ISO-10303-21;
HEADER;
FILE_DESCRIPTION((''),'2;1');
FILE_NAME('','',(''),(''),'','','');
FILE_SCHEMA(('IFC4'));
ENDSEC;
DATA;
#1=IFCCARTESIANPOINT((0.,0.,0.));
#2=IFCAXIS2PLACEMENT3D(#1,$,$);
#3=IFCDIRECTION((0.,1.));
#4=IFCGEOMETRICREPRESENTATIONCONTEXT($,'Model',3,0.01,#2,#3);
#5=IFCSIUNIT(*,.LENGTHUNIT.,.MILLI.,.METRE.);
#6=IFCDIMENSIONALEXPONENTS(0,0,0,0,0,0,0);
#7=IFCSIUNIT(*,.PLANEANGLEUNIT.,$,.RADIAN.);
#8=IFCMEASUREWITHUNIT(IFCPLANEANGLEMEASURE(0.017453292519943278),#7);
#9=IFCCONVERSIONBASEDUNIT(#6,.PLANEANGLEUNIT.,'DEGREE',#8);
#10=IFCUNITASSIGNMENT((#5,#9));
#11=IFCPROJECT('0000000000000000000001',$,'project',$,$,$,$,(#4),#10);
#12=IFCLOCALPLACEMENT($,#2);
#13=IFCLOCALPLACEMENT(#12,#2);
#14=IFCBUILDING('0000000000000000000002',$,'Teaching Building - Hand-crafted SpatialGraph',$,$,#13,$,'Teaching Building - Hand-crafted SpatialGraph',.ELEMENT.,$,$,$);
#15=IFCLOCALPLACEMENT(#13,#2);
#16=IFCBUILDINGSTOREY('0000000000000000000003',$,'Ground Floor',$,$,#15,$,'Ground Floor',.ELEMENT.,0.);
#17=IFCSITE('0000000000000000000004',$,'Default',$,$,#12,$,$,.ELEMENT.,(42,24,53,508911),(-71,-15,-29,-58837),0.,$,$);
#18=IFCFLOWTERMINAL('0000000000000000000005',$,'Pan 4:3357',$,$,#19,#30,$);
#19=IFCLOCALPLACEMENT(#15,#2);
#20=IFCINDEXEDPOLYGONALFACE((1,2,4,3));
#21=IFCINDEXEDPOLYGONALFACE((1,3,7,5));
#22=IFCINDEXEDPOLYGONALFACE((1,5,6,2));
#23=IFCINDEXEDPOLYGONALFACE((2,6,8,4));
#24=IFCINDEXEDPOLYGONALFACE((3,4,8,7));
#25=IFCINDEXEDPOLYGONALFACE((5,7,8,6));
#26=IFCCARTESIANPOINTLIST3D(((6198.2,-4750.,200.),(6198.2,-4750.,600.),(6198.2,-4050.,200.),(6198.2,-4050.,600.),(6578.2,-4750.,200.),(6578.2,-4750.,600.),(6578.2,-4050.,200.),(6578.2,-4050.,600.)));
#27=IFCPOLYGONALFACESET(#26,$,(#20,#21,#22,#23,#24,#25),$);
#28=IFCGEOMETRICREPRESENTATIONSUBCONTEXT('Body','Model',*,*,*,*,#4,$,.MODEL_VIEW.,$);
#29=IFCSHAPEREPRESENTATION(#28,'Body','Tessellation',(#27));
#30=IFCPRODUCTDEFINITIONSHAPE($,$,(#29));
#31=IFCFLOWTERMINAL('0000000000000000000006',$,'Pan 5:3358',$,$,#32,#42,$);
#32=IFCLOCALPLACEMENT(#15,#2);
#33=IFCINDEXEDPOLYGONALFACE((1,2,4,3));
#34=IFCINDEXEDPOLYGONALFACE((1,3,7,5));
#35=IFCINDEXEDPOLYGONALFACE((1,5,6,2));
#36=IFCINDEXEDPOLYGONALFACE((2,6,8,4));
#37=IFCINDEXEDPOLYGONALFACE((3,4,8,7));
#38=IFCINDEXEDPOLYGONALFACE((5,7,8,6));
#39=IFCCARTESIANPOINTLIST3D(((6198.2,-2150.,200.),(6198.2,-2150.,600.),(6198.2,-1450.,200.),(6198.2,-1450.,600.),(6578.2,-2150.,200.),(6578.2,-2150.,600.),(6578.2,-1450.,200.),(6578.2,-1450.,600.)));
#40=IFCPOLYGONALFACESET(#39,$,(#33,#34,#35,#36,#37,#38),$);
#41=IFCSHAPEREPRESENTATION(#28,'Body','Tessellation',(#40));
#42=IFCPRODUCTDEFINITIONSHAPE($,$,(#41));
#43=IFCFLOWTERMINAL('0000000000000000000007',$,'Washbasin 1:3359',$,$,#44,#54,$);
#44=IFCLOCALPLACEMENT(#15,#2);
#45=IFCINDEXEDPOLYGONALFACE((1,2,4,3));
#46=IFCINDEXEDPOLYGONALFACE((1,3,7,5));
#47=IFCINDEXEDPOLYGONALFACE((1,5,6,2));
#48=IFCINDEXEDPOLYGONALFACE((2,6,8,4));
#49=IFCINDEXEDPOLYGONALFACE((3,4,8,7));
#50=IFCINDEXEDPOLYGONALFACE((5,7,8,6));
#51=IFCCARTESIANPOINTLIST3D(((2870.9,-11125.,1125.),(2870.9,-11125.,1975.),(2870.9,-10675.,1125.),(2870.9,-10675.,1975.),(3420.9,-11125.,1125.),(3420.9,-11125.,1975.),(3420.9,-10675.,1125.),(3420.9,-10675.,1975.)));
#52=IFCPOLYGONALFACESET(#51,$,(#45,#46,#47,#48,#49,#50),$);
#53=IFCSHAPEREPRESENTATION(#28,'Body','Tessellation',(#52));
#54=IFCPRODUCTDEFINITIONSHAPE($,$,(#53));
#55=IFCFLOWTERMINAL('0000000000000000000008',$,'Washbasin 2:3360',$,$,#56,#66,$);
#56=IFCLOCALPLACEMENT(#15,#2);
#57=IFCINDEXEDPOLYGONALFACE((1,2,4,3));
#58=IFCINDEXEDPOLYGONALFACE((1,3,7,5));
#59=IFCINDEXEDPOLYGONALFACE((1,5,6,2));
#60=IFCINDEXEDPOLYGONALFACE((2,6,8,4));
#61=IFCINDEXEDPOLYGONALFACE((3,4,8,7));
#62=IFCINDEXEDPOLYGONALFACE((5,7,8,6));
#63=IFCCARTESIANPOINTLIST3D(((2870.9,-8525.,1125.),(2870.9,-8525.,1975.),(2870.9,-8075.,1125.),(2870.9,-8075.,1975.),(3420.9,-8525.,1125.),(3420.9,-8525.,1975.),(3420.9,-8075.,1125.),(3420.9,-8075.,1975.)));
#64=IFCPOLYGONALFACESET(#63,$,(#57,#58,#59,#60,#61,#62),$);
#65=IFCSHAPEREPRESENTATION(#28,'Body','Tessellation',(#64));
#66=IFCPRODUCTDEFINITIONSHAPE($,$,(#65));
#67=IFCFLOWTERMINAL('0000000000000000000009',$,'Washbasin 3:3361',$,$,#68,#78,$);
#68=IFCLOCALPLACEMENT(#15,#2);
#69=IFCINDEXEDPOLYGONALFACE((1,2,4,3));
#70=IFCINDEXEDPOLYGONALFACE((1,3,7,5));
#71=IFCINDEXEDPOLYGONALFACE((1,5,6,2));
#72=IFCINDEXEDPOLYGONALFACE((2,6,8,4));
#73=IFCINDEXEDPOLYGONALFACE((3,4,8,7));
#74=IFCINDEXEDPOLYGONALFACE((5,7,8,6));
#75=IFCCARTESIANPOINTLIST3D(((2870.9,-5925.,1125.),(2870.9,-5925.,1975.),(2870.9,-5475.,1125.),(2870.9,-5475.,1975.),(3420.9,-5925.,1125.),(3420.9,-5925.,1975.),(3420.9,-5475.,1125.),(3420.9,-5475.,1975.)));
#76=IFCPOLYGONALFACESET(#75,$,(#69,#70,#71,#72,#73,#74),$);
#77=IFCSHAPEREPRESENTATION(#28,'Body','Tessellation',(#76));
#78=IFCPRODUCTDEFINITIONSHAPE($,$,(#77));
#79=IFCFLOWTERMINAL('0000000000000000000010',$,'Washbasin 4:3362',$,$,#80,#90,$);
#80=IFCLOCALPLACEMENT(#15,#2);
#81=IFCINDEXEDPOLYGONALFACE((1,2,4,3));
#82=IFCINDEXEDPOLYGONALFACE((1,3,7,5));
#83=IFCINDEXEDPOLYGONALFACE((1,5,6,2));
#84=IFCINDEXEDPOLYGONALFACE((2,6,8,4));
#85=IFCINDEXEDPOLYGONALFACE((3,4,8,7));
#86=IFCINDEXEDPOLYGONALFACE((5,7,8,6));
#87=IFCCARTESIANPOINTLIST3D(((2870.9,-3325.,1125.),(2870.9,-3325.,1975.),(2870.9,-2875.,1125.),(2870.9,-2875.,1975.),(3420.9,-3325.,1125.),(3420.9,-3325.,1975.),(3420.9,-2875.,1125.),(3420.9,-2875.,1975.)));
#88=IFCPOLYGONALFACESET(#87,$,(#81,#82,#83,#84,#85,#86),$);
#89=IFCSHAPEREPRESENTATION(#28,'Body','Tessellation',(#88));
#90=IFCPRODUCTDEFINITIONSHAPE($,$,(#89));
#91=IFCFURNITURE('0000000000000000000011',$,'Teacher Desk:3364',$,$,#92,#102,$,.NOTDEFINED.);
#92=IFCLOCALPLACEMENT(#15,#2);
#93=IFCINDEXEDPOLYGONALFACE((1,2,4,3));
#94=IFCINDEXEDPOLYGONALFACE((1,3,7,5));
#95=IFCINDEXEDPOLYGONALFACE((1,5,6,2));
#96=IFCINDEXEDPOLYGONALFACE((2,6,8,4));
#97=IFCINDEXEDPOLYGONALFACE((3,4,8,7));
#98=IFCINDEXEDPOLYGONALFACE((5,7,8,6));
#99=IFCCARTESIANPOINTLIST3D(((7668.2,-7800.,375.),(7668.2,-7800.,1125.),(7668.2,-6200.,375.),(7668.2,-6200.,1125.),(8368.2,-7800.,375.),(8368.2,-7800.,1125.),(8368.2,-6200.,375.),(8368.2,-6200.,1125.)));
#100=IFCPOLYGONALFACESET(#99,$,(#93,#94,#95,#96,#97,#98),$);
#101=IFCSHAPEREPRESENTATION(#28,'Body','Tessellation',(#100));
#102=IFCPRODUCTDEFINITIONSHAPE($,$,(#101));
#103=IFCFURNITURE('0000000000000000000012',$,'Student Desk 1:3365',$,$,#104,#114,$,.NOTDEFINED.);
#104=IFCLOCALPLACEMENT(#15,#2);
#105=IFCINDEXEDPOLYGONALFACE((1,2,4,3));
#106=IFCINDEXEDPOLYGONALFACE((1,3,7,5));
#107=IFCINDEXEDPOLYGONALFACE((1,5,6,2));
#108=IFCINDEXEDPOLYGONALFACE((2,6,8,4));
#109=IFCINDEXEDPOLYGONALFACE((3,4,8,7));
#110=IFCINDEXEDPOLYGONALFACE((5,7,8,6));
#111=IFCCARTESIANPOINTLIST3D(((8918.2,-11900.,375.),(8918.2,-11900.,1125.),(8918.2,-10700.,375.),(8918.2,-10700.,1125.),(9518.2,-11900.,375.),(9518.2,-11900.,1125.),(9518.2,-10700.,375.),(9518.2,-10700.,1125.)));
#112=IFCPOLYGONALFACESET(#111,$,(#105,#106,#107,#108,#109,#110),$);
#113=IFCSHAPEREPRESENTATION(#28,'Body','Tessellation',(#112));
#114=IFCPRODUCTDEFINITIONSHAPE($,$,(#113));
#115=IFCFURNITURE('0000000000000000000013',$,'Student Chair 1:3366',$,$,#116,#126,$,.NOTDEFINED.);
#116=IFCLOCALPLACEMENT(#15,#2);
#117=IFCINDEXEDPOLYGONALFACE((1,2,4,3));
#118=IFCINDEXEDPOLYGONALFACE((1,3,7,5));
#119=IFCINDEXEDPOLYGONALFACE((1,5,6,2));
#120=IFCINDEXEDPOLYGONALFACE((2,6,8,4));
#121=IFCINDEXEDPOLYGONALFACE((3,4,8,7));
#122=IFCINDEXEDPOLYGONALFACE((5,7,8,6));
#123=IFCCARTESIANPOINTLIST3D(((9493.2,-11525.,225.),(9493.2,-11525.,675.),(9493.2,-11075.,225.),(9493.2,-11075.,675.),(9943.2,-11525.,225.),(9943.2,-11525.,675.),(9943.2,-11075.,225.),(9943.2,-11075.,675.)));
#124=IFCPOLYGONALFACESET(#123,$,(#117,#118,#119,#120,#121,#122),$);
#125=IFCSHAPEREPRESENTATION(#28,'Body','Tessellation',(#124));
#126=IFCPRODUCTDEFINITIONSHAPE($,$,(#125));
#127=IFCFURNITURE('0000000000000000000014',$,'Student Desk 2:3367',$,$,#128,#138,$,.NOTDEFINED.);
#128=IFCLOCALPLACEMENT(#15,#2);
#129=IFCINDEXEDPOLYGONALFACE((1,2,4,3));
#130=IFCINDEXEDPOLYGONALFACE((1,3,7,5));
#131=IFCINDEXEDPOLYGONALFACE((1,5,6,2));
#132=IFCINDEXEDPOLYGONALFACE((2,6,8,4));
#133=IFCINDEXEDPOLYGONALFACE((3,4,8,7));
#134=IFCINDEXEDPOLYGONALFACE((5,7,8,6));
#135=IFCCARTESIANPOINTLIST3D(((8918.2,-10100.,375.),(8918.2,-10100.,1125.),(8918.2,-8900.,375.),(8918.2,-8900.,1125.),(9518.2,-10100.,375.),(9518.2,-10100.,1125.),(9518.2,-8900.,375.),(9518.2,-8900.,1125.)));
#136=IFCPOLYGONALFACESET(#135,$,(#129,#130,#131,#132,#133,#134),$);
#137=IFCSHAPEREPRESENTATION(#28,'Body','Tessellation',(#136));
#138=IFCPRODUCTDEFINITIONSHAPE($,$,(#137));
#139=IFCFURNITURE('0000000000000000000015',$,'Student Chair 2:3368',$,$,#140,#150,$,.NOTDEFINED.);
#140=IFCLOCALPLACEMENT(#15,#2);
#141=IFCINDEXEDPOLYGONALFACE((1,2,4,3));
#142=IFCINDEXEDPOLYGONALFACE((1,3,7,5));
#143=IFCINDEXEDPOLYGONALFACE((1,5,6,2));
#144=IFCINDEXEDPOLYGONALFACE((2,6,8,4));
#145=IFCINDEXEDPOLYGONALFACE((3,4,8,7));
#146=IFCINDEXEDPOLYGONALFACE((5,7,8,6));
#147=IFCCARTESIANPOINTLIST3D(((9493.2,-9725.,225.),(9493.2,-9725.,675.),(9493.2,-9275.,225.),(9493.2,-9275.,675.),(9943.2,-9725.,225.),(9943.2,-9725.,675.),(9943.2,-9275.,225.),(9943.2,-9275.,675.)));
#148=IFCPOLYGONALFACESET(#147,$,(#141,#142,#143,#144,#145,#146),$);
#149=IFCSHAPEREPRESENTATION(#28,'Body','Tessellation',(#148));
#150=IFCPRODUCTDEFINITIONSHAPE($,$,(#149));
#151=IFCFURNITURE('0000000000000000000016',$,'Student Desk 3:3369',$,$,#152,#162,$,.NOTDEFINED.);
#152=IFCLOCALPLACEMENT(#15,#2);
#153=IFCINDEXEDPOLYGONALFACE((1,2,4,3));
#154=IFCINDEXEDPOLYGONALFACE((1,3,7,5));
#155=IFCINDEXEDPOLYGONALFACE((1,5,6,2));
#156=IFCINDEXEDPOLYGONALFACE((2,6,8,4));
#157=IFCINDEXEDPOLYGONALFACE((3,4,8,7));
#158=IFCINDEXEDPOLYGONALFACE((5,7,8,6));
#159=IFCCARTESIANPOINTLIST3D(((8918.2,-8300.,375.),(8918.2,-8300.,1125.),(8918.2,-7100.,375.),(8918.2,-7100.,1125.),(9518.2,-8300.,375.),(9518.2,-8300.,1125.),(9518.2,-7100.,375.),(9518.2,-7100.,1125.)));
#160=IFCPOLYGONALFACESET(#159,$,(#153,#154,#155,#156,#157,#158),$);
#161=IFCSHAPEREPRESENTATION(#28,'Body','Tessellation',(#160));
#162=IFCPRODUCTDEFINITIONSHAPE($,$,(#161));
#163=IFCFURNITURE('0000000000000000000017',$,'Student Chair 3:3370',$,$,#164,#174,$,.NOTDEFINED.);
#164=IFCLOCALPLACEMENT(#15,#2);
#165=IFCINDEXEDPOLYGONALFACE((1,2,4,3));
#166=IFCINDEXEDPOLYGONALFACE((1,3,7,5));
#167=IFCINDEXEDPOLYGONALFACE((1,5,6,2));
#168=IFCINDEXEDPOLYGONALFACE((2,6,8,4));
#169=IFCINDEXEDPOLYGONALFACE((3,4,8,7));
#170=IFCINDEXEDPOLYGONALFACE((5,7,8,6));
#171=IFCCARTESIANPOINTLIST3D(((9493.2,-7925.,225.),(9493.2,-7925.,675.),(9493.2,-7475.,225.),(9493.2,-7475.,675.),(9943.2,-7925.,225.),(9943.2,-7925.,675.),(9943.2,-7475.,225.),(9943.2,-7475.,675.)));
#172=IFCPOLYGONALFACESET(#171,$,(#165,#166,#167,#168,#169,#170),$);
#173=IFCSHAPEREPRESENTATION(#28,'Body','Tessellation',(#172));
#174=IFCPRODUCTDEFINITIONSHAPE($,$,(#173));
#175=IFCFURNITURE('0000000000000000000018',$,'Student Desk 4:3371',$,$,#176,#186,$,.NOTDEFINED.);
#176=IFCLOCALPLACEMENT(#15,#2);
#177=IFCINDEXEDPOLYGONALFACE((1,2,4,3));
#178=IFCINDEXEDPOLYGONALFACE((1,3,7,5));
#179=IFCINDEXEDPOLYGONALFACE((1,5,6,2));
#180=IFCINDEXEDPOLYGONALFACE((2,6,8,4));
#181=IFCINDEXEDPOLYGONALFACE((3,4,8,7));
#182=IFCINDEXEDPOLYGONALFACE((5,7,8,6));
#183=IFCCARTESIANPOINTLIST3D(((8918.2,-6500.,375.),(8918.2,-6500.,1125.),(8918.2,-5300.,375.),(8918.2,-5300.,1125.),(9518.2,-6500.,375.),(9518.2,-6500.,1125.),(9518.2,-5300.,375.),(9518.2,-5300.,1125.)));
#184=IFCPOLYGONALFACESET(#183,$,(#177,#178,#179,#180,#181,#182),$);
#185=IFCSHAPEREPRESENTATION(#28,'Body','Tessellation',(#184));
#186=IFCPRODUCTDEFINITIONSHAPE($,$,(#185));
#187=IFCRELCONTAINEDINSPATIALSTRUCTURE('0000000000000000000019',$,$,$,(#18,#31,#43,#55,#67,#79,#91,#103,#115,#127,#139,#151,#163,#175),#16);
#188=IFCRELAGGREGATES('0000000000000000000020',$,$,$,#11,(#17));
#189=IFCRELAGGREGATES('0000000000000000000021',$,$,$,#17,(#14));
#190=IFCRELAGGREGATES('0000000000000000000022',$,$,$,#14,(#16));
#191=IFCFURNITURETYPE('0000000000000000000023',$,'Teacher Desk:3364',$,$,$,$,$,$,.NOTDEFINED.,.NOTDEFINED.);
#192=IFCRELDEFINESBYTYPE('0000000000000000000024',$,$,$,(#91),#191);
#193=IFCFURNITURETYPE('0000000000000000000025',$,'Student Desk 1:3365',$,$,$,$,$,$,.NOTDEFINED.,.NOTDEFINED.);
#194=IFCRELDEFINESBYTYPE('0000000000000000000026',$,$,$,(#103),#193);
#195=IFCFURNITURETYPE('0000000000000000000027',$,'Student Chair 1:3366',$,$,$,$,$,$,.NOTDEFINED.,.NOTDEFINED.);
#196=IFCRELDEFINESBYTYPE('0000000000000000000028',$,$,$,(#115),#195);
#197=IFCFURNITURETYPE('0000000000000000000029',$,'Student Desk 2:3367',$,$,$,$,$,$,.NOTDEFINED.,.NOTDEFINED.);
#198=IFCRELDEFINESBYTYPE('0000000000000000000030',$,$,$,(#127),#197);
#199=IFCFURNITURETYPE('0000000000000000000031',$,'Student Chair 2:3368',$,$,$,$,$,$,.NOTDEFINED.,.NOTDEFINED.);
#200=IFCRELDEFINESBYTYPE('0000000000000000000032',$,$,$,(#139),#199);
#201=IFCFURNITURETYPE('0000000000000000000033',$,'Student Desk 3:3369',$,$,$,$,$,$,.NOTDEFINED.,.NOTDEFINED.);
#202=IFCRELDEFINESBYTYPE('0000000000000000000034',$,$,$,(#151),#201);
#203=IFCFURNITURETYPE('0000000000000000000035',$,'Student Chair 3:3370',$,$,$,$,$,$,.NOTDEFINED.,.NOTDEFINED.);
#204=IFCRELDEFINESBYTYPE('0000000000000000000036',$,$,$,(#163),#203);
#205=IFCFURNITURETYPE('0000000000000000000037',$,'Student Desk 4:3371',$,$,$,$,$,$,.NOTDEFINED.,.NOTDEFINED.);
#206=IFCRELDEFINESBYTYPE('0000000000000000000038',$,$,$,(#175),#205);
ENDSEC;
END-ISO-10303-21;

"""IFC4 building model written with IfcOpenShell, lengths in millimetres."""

from ifc_helpers import new_model, entity, si_unit, converted_unit, direction, frame, frame_2d, origin, origin_2d_with_axis, place, context, subcontext, project, spatial, rectangle, extrude, type_object, element, save


model = new_model("IFC4")

# Units and contexts
model_context = context("Model", 3, precision=0.01, world=origin(), true_north=direction((0.0, 1.0)))
body_context = subcontext(model_context, "Body", "Model", "MODEL_VIEW")
ifc_project = project(units=[si_unit("LENGTHUNIT", "METRE", prefix="MILLI"), converted_unit("PLANEANGLEUNIT", "DEGREE", entity("IfcPlaneAngleMeasure", 0.017453292519943278), si_unit("PLANEANGLEUNIT", "RADIAN"), dimensions=[0, 0, 0, 0, 0, 0, 0])], contexts=[model_context])

# Site, building, storey
site_placement = place(None, origin())
site = spatial("IfcSite", under=ifc_project, at=site_placement, Name="Default", CompositionType="ELEMENT", RefLatitude=(42, 24, 53, 508911), RefLongitude=(-71, -15, -29, -58837), RefElevation=0.0)
building_placement = place(site_placement, origin())
building = spatial("IfcBuilding", under=site, at=building_placement, Name="Teaching Building - Hand-crafted SpatialGraph", LongName="Teaching Building - Hand-crafted SpatialGraph", CompositionType="ELEMENT")
storey_placement = place(building_placement, origin())
storey = spatial("IfcBuildingStorey", under=building, at=storey_placement, Name="Ground Floor", LongName="Ground Floor", CompositionType="ELEMENT", Elevation=0.0)

# Flow terminals
flow_terminal_1_placement = place(storey_placement, origin())
element("IfcFlowTerminal", 1, at=flow_terminal_1_placement, inside=storey, Name="Pan 4:3357", context=body_context, shape_type="SweptSolid", body=[
    extrude(rectangle(XDim=700.0, YDim=380.0, at=frame_2d((0.0, 0.0), x_axis=(1.0, 0.0))), frame((6388.2, -4400.0, 200.0), z_axis=(0.0, 0.0, 1.0), x_axis=(0.0, 1.0, 0.0)), (0.0, 0.0, 1.0), 400.0),
])
flow_terminal_2_placement = place(storey_placement, origin())
element("IfcFlowTerminal", 2, at=flow_terminal_2_placement, inside=storey, Name="Pan 5:3358", context=body_context, shape_type="SweptSolid", body=[
    extrude(rectangle(XDim=700.0, YDim=380.0, at=origin_2d_with_axis()), frame((6388.2, -1800.0, 200.0), z_axis=(0.0, 0.0, 1.0), x_axis=(0.0, 1.0, 0.0)), (0.0, 0.0, 1.0), 400.0),
])
flow_terminal_3_placement = place(storey_placement, origin())
element("IfcFlowTerminal", 3, at=flow_terminal_3_placement, inside=storey, Name="Washbasin 1:3359", context=body_context, shape_type="SweptSolid", body=[
    extrude(rectangle(XDim=450.0, YDim=550.0, at=origin_2d_with_axis()), frame((3145.9, -10900.0, 1125.0), z_axis=(0.0, 0.0, 1.0), x_axis=(0.0, 1.0, 0.0)), (0.0, 0.0, 1.0), 850.0),
])
flow_terminal_4_placement = place(storey_placement, origin())
element("IfcFlowTerminal", 4, at=flow_terminal_4_placement, inside=storey, Name="Washbasin 2:3360", context=body_context, shape_type="SweptSolid", body=[
    extrude(rectangle(XDim=450.0, YDim=550.0, at=origin_2d_with_axis()), frame((3145.9, -8300.0, 1125.0), z_axis=(0.0, 0.0, 1.0), x_axis=(0.0, 1.0, 0.0)), (0.0, 0.0, 1.0), 850.0),
])
flow_terminal_5_placement = place(storey_placement, origin())
element("IfcFlowTerminal", 5, at=flow_terminal_5_placement, inside=storey, Name="Washbasin 3:3361", context=body_context, shape_type="SweptSolid", body=[
    extrude(rectangle(XDim=450.0, YDim=550.0, at=origin_2d_with_axis()), frame((3145.9, -5700.0, 1125.0), z_axis=(0.0, 0.0, 1.0), x_axis=(0.0, 1.0, 0.0)), (0.0, 0.0, 1.0), 850.0),
])
flow_terminal_6_placement = place(storey_placement, origin())
element("IfcFlowTerminal", 6, at=flow_terminal_6_placement, inside=storey, Name="Washbasin 4:3362", context=body_context, shape_type="SweptSolid", body=[
    extrude(rectangle(XDim=450.0, YDim=550.0, at=origin_2d_with_axis()), frame((3145.9, -3100.0, 1125.0), z_axis=(0.0, 0.0, 1.0), x_axis=(0.0, 1.0, 0.0)), (0.0, 0.0, 1.0), 850.0),
])

# Furniture
furniture_type_1 = type_object("IfcFurnitureType", Name="Teacher Desk:3364", PredefinedType="NOTDEFINED")
furniture_1_placement = place(storey_placement, origin())
element("IfcFurniture", 7, at=furniture_1_placement, inside=storey, type_object=furniture_type_1, Name="Teacher Desk:3364", PredefinedType="NOTDEFINED", context=body_context, shape_type="SweptSolid", body=[
    extrude(rectangle(XDim=1600.0, YDim=700.0, at=origin_2d_with_axis()), frame((8018.2, -7000.0, 375.0), z_axis=(0.0, 0.0, 1.0), x_axis=(0.0, 1.0, 0.0)), (0.0, 0.0, 1.0), 750.0),
])
furniture_type_2 = type_object("IfcFurnitureType", Name="Student Desk 1:3365", PredefinedType="NOTDEFINED")
furniture_2_placement = place(storey_placement, origin())
element("IfcFurniture", 8, at=furniture_2_placement, inside=storey, type_object=furniture_type_2, Name="Student Desk 1:3365", PredefinedType="NOTDEFINED", context=body_context, shape_type="SweptSolid", body=[
    extrude(rectangle(XDim=1200.0, YDim=600.0, at=frame_2d((0.0, 0.0), x_axis=(1.0, 0.0))), frame((9218.2, -11300.0, 375.0), z_axis=(0.0, 0.0, 1.0), x_axis=(0.0, 1.0, 0.0)), (0.0, 0.0, 1.0), 750.0),
])
furniture_type_3 = type_object("IfcFurnitureType", Name="Student Chair 1:3366", PredefinedType="NOTDEFINED")
furniture_3_placement = place(storey_placement, origin())
element("IfcFurniture", 9, at=furniture_3_placement, inside=storey, type_object=furniture_type_3, Name="Student Chair 1:3366", PredefinedType="NOTDEFINED", context=body_context, shape_type="SweptSolid", body=[
    extrude(rectangle(XDim=450.0, YDim=450.0, at=frame_2d((0.0, 0.0), x_axis=(1.0, 0.0))), frame((9718.2, -11300.0, 225.0)), (0.0, 0.0, 1.0), 450.0),
])
furniture_type_4 = type_object("IfcFurnitureType", Name="Student Desk 2:3367", PredefinedType="NOTDEFINED")
furniture_4_placement = place(storey_placement, origin())
element("IfcFurniture", 10, at=furniture_4_placement, inside=storey, type_object=furniture_type_4, Name="Student Desk 2:3367", PredefinedType="NOTDEFINED", context=body_context, shape_type="SweptSolid", body=[
    extrude(rectangle(XDim=1200.0, YDim=600.0, at=frame_2d((0.0, 0.0), x_axis=(1.0, 0.0))), frame((9218.2, -9500.0, 375.0), z_axis=(0.0, 0.0, 1.0), x_axis=(0.0, 1.0, 0.0)), (0.0, 0.0, 1.0), 750.0),
])
furniture_type_5 = type_object("IfcFurnitureType", Name="Student Chair 2:3368", PredefinedType="NOTDEFINED")
furniture_5_placement = place(storey_placement, origin())
element("IfcFurniture", 11, at=furniture_5_placement, inside=storey, type_object=furniture_type_5, Name="Student Chair 2:3368", PredefinedType="NOTDEFINED", context=body_context, shape_type="SweptSolid", body=[
    extrude(rectangle(XDim=450.0, YDim=450.0, at=frame_2d((0.0, 0.0), x_axis=(1.0, 0.0))), frame((9718.2, -9500.0, 225.0)), (0.0, 0.0, 1.0), 450.0),
])
furniture_type_6 = type_object("IfcFurnitureType", Name="Student Desk 3:3369", PredefinedType="NOTDEFINED")
furniture_6_placement = place(storey_placement, origin())
element("IfcFurniture", 12, at=furniture_6_placement, inside=storey, type_object=furniture_type_6, Name="Student Desk 3:3369", PredefinedType="NOTDEFINED", context=body_context, shape_type="SweptSolid", body=[
    extrude(rectangle(XDim=1200.0, YDim=600.0, at=frame_2d((0.0, 0.0), x_axis=(1.0, 0.0))), frame((9218.2, -7700.0, 375.0), z_axis=(0.0, 0.0, 1.0), x_axis=(0.0, 1.0, 0.0)), (0.0, 0.0, 1.0), 750.0),
])
furniture_type_7 = type_object("IfcFurnitureType", Name="Student Chair 3:3370", PredefinedType="NOTDEFINED")
furniture_7_placement = place(storey_placement, origin())
element("IfcFurniture", 13, at=furniture_7_placement, inside=storey, type_object=furniture_type_7, Name="Student Chair 3:3370", PredefinedType="NOTDEFINED", context=body_context, shape_type="SweptSolid", body=[
    extrude(rectangle(XDim=450.0, YDim=450.0, at=frame_2d((0.0, 0.0), x_axis=(1.0, 0.0))), frame((9718.2, -7700.0, 225.0)), (0.0, 0.0, 1.0), 450.0),
])
furniture_type_8 = type_object("IfcFurnitureType", Name="Student Desk 4:3371", PredefinedType="NOTDEFINED")
furniture_8_placement = place(storey_placement, origin())
element("IfcFurniture", 14, at=furniture_8_placement, inside=storey, type_object=furniture_type_8, Name="Student Desk 4:3371", PredefinedType="NOTDEFINED", context=body_context, shape_type="SweptSolid", body=[
    extrude(rectangle(XDim=1200.0, YDim=600.0, at=frame_2d((0.0, 0.0), x_axis=(1.0, 0.0))), frame((9218.2, -5900.0, 375.0), z_axis=(0.0, 0.0, 1.0), x_axis=(0.0, 1.0, 0.0)), (0.0, 0.0, 1.0), 750.0),
])

save(model, "model.ifc")
